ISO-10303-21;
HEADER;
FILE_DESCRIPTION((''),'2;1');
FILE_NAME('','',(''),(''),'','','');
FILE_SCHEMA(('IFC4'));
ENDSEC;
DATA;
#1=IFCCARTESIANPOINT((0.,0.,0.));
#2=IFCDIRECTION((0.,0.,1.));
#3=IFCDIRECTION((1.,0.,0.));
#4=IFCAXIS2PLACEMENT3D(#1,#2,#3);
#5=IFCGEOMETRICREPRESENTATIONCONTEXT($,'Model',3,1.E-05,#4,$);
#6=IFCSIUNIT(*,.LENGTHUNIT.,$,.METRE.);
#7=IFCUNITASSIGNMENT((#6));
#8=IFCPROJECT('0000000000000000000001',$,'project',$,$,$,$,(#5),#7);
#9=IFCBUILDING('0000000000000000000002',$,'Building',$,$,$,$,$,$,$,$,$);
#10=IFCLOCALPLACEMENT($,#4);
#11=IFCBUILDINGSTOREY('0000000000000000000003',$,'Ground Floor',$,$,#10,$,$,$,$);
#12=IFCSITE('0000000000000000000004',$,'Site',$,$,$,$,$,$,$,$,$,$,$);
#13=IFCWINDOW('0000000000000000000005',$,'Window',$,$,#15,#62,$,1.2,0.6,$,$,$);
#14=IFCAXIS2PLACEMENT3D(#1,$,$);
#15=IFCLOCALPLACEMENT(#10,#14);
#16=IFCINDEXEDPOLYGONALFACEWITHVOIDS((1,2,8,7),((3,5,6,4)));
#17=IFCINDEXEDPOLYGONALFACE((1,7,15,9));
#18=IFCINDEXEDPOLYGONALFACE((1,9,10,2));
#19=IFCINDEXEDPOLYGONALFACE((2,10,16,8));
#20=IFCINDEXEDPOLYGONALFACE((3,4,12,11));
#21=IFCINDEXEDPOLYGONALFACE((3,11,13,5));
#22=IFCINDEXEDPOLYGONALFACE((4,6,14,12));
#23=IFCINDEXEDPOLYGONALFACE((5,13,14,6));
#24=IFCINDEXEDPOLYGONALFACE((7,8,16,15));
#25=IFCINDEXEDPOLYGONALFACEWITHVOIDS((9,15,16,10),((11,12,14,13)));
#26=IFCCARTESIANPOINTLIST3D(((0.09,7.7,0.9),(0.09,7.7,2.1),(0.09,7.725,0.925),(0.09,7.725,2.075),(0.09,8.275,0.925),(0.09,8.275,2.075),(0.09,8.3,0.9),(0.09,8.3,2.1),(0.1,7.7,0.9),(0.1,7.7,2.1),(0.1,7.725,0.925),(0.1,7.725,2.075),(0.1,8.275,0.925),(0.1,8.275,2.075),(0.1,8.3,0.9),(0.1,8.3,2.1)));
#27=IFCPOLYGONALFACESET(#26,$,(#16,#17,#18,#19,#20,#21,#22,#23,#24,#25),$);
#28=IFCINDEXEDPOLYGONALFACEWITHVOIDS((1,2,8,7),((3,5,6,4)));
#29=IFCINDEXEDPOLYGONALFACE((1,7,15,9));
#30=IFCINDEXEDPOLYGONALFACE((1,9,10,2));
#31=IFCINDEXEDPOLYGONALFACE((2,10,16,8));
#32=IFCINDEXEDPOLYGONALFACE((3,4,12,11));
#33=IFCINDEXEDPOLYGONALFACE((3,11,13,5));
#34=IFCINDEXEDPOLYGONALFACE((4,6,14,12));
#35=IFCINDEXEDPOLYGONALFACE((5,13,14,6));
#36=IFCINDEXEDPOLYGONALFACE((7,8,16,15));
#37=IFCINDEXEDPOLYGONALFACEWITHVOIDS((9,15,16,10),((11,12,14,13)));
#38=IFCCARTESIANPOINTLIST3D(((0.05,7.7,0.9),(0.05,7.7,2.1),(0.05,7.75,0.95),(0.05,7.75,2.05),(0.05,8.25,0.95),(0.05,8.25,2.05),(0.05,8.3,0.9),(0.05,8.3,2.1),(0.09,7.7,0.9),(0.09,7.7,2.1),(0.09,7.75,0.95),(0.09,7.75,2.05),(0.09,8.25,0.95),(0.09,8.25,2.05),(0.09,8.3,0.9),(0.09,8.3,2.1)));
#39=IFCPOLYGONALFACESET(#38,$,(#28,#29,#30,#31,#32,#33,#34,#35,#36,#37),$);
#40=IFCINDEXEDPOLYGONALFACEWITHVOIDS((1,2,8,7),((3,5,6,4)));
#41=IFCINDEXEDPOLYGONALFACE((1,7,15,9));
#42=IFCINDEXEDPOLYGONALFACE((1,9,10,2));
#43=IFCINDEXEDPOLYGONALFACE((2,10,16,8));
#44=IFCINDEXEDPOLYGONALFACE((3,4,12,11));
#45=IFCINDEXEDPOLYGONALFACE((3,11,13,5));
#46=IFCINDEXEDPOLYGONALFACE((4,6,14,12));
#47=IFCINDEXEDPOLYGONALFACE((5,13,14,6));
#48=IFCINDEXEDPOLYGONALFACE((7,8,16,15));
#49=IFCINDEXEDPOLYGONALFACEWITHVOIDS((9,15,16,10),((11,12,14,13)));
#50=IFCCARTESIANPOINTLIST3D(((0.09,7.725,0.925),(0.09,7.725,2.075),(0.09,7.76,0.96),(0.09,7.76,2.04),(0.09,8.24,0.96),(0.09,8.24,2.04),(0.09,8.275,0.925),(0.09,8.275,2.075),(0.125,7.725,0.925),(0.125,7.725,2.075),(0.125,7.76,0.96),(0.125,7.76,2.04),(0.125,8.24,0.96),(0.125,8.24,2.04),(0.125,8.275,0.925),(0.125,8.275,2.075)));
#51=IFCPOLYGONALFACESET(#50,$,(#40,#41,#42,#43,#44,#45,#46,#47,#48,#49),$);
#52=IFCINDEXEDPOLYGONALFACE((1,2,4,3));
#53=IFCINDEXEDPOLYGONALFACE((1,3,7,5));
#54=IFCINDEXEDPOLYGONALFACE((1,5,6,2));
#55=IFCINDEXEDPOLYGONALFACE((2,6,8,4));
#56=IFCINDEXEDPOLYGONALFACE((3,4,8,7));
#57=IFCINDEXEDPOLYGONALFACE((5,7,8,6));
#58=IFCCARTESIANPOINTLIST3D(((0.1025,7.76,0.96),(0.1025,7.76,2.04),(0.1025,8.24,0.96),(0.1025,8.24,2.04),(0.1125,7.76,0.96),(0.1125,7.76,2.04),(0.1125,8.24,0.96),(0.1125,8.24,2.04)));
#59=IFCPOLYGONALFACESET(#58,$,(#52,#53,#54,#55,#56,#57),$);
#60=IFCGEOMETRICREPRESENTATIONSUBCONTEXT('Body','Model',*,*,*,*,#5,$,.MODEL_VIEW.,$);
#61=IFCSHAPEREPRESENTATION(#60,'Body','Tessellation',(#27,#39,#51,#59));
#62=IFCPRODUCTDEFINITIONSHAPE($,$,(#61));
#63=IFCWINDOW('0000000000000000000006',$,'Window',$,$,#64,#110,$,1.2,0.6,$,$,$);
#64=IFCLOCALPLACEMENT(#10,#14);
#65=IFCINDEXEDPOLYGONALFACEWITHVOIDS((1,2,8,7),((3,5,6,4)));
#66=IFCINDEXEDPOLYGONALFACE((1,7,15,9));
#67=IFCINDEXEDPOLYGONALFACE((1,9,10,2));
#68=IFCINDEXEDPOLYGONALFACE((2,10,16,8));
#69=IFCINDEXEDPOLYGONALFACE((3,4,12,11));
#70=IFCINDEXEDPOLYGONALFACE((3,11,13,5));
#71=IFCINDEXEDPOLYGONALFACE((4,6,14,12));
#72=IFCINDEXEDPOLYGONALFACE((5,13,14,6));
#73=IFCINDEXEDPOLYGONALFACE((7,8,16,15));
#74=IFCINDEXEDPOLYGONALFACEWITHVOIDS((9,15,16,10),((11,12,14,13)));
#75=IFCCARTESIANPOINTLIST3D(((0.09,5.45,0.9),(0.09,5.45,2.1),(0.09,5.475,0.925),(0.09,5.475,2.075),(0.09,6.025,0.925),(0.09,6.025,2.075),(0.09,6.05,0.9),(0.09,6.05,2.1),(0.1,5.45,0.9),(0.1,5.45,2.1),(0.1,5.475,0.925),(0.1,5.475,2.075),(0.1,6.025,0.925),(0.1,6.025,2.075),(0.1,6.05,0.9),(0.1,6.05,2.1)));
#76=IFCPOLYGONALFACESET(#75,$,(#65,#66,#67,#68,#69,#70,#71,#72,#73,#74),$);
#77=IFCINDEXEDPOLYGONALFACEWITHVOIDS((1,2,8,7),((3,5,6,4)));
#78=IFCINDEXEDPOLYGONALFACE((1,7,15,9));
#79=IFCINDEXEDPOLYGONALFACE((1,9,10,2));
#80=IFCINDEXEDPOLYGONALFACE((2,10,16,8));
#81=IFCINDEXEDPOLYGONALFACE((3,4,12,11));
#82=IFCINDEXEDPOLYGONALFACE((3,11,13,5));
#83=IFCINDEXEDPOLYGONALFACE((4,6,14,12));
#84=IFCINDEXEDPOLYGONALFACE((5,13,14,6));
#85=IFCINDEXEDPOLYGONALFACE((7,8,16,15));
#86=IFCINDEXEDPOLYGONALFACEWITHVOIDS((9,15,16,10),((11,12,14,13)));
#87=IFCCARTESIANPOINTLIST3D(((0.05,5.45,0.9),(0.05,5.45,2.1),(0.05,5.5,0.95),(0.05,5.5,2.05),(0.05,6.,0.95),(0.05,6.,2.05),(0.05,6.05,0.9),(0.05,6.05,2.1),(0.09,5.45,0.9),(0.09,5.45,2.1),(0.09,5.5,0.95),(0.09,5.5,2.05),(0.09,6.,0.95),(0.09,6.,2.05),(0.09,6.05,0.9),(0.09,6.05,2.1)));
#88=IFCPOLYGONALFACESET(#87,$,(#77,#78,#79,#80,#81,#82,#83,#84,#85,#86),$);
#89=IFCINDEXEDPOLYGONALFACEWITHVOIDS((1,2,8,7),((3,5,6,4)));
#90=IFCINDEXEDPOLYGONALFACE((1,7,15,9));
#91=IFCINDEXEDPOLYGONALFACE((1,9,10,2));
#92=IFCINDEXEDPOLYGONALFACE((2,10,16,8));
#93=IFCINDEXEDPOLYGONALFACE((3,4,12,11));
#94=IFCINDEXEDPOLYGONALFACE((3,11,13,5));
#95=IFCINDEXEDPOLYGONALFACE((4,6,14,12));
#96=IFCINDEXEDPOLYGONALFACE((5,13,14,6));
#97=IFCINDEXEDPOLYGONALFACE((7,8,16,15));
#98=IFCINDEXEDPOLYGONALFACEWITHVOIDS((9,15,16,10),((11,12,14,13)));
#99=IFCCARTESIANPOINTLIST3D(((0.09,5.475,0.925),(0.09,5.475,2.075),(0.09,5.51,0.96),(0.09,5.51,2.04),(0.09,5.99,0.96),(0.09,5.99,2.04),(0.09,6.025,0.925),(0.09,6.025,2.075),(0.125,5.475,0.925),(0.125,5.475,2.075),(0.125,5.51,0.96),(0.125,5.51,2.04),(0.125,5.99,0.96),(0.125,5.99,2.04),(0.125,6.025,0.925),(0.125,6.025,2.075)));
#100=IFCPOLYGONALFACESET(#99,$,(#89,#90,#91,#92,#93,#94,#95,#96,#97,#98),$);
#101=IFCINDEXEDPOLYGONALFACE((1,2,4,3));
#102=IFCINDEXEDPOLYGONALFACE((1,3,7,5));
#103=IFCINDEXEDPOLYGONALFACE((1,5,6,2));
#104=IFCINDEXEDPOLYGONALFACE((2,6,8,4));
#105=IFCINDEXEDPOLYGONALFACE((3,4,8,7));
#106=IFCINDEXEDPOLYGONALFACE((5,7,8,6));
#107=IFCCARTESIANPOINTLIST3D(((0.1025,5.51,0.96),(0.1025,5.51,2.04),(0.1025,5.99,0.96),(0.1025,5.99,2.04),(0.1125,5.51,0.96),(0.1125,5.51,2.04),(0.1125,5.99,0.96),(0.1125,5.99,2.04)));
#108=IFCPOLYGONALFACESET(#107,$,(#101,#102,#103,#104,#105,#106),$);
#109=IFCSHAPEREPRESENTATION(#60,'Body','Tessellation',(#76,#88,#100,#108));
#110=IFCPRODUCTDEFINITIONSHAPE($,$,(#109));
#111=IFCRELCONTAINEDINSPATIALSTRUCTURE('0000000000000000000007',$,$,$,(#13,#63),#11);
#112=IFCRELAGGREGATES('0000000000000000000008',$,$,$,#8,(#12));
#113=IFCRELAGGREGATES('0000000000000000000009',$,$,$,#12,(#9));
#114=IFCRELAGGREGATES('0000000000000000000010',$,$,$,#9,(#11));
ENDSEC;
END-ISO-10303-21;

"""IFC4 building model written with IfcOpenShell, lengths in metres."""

from ifc_helpers import new_model, si_unit, frame, origin_with_axes, place, context, subcontext, project, spatial, line, indexed_curve, outline, extrude, element, save


model = new_model("IFC4")

# Units and contexts
model_context = context("Model", 3, precision=1e-05, world=origin_with_axes())
body_context = subcontext(model_context, "Body", "Model", "MODEL_VIEW")
ifc_project = project(units=[si_unit("LENGTHUNIT", "METRE")], contexts=[model_context])

# Site, building, storey
site = spatial("IfcSite", under=ifc_project, Name="Site")
building = spatial("IfcBuilding", under=site, Name="Building")
storey_placement = place(None, origin_with_axes())
storey = spatial("IfcBuildingStorey", under=building, at=storey_placement, Name="Ground Floor")

# Windows
for number, where, z_axis, x_axis, name in (
    (1, (0.0, 8.3, 0.9), (0.0, 0.0, 1.0), (0.0, -1.0, 0.0), "Window"),
    (2, (0.0, 6.05, 0.9), (0.0, 0.0, 1.0), (0.0, -1.0, 0.0), "Window"),
):
    element("IfcWindow", number, at=place(storey_placement, frame(where, z_axis=z_axis, x_axis=x_axis)), inside=storey, Name=name, OverallHeight=1.2, OverallWidth=0.6, context=body_context, shape_type="SweptSolid", body=[
        extrude(outline(indexed_curve([(0.0, 0.0), (0.6, 0.0), (0.6, 1.2), (0.0, 1.2)], segments=[line(1, 2, 3, 4, 1)]), holes=[indexed_curve([(0.025, 0.025), (0.575, 0.025), (0.575, 1.175), (0.025, 1.175)], segments=[line(1, 2, 3, 4, 1)])]), frame((0.0, 0.09, 0.0), z_axis=(0.0, -1.0, 0.0), x_axis=(1.0, 0.0, 0.0)), (0.0, 0.0, -1.0), 0.01),
        extrude(outline(indexed_curve([(0.0, 0.0), (0.6, 0.0), (0.6, 1.2), (0.0, 1.2)], segments=[line(1, 2, 3, 4, 1)]), holes=[indexed_curve([(0.05, 0.05), (0.55, 0.05), (0.55, 1.15), (0.05, 1.15)], segments=[line(1, 2, 3, 4, 1)])]), frame((0.0, 0.05, 0.0), z_axis=(0.0, -1.0, 0.0), x_axis=(1.0, 0.0, 0.0)), (0.0, 0.0, -1.0), 0.04),
        extrude(outline(indexed_curve([(0.0, 0.0), (0.55, 0.0), (0.55, 1.15), (0.0, 1.15)], segments=[line(1, 2, 3, 4, 1)]), holes=[indexed_curve([(0.035, 0.035), (0.515, 0.035), (0.515, 1.115), (0.035, 1.115)], segments=[line(1, 2, 3, 4, 1)])]), frame((0.025, 0.09, 0.025), z_axis=(0.0, -1.0, 0.0), x_axis=(1.0, 0.0, 0.0)), (0.0, 0.0, -1.0), 0.035),
        extrude(outline(indexed_curve([(0.035, 0.035), (0.515, 0.035), (0.515, 1.115), (0.035, 1.115)], segments=[line(1, 2, 3, 4, 1)])), frame((0.025, 0.1025, 0.025), z_axis=(0.0, -1.0, 0.0), x_axis=(1.0, 0.0, 0.0)), (0.0, 0.0, -1.0), 0.01),
    ])

save(model, "model.ifc")
